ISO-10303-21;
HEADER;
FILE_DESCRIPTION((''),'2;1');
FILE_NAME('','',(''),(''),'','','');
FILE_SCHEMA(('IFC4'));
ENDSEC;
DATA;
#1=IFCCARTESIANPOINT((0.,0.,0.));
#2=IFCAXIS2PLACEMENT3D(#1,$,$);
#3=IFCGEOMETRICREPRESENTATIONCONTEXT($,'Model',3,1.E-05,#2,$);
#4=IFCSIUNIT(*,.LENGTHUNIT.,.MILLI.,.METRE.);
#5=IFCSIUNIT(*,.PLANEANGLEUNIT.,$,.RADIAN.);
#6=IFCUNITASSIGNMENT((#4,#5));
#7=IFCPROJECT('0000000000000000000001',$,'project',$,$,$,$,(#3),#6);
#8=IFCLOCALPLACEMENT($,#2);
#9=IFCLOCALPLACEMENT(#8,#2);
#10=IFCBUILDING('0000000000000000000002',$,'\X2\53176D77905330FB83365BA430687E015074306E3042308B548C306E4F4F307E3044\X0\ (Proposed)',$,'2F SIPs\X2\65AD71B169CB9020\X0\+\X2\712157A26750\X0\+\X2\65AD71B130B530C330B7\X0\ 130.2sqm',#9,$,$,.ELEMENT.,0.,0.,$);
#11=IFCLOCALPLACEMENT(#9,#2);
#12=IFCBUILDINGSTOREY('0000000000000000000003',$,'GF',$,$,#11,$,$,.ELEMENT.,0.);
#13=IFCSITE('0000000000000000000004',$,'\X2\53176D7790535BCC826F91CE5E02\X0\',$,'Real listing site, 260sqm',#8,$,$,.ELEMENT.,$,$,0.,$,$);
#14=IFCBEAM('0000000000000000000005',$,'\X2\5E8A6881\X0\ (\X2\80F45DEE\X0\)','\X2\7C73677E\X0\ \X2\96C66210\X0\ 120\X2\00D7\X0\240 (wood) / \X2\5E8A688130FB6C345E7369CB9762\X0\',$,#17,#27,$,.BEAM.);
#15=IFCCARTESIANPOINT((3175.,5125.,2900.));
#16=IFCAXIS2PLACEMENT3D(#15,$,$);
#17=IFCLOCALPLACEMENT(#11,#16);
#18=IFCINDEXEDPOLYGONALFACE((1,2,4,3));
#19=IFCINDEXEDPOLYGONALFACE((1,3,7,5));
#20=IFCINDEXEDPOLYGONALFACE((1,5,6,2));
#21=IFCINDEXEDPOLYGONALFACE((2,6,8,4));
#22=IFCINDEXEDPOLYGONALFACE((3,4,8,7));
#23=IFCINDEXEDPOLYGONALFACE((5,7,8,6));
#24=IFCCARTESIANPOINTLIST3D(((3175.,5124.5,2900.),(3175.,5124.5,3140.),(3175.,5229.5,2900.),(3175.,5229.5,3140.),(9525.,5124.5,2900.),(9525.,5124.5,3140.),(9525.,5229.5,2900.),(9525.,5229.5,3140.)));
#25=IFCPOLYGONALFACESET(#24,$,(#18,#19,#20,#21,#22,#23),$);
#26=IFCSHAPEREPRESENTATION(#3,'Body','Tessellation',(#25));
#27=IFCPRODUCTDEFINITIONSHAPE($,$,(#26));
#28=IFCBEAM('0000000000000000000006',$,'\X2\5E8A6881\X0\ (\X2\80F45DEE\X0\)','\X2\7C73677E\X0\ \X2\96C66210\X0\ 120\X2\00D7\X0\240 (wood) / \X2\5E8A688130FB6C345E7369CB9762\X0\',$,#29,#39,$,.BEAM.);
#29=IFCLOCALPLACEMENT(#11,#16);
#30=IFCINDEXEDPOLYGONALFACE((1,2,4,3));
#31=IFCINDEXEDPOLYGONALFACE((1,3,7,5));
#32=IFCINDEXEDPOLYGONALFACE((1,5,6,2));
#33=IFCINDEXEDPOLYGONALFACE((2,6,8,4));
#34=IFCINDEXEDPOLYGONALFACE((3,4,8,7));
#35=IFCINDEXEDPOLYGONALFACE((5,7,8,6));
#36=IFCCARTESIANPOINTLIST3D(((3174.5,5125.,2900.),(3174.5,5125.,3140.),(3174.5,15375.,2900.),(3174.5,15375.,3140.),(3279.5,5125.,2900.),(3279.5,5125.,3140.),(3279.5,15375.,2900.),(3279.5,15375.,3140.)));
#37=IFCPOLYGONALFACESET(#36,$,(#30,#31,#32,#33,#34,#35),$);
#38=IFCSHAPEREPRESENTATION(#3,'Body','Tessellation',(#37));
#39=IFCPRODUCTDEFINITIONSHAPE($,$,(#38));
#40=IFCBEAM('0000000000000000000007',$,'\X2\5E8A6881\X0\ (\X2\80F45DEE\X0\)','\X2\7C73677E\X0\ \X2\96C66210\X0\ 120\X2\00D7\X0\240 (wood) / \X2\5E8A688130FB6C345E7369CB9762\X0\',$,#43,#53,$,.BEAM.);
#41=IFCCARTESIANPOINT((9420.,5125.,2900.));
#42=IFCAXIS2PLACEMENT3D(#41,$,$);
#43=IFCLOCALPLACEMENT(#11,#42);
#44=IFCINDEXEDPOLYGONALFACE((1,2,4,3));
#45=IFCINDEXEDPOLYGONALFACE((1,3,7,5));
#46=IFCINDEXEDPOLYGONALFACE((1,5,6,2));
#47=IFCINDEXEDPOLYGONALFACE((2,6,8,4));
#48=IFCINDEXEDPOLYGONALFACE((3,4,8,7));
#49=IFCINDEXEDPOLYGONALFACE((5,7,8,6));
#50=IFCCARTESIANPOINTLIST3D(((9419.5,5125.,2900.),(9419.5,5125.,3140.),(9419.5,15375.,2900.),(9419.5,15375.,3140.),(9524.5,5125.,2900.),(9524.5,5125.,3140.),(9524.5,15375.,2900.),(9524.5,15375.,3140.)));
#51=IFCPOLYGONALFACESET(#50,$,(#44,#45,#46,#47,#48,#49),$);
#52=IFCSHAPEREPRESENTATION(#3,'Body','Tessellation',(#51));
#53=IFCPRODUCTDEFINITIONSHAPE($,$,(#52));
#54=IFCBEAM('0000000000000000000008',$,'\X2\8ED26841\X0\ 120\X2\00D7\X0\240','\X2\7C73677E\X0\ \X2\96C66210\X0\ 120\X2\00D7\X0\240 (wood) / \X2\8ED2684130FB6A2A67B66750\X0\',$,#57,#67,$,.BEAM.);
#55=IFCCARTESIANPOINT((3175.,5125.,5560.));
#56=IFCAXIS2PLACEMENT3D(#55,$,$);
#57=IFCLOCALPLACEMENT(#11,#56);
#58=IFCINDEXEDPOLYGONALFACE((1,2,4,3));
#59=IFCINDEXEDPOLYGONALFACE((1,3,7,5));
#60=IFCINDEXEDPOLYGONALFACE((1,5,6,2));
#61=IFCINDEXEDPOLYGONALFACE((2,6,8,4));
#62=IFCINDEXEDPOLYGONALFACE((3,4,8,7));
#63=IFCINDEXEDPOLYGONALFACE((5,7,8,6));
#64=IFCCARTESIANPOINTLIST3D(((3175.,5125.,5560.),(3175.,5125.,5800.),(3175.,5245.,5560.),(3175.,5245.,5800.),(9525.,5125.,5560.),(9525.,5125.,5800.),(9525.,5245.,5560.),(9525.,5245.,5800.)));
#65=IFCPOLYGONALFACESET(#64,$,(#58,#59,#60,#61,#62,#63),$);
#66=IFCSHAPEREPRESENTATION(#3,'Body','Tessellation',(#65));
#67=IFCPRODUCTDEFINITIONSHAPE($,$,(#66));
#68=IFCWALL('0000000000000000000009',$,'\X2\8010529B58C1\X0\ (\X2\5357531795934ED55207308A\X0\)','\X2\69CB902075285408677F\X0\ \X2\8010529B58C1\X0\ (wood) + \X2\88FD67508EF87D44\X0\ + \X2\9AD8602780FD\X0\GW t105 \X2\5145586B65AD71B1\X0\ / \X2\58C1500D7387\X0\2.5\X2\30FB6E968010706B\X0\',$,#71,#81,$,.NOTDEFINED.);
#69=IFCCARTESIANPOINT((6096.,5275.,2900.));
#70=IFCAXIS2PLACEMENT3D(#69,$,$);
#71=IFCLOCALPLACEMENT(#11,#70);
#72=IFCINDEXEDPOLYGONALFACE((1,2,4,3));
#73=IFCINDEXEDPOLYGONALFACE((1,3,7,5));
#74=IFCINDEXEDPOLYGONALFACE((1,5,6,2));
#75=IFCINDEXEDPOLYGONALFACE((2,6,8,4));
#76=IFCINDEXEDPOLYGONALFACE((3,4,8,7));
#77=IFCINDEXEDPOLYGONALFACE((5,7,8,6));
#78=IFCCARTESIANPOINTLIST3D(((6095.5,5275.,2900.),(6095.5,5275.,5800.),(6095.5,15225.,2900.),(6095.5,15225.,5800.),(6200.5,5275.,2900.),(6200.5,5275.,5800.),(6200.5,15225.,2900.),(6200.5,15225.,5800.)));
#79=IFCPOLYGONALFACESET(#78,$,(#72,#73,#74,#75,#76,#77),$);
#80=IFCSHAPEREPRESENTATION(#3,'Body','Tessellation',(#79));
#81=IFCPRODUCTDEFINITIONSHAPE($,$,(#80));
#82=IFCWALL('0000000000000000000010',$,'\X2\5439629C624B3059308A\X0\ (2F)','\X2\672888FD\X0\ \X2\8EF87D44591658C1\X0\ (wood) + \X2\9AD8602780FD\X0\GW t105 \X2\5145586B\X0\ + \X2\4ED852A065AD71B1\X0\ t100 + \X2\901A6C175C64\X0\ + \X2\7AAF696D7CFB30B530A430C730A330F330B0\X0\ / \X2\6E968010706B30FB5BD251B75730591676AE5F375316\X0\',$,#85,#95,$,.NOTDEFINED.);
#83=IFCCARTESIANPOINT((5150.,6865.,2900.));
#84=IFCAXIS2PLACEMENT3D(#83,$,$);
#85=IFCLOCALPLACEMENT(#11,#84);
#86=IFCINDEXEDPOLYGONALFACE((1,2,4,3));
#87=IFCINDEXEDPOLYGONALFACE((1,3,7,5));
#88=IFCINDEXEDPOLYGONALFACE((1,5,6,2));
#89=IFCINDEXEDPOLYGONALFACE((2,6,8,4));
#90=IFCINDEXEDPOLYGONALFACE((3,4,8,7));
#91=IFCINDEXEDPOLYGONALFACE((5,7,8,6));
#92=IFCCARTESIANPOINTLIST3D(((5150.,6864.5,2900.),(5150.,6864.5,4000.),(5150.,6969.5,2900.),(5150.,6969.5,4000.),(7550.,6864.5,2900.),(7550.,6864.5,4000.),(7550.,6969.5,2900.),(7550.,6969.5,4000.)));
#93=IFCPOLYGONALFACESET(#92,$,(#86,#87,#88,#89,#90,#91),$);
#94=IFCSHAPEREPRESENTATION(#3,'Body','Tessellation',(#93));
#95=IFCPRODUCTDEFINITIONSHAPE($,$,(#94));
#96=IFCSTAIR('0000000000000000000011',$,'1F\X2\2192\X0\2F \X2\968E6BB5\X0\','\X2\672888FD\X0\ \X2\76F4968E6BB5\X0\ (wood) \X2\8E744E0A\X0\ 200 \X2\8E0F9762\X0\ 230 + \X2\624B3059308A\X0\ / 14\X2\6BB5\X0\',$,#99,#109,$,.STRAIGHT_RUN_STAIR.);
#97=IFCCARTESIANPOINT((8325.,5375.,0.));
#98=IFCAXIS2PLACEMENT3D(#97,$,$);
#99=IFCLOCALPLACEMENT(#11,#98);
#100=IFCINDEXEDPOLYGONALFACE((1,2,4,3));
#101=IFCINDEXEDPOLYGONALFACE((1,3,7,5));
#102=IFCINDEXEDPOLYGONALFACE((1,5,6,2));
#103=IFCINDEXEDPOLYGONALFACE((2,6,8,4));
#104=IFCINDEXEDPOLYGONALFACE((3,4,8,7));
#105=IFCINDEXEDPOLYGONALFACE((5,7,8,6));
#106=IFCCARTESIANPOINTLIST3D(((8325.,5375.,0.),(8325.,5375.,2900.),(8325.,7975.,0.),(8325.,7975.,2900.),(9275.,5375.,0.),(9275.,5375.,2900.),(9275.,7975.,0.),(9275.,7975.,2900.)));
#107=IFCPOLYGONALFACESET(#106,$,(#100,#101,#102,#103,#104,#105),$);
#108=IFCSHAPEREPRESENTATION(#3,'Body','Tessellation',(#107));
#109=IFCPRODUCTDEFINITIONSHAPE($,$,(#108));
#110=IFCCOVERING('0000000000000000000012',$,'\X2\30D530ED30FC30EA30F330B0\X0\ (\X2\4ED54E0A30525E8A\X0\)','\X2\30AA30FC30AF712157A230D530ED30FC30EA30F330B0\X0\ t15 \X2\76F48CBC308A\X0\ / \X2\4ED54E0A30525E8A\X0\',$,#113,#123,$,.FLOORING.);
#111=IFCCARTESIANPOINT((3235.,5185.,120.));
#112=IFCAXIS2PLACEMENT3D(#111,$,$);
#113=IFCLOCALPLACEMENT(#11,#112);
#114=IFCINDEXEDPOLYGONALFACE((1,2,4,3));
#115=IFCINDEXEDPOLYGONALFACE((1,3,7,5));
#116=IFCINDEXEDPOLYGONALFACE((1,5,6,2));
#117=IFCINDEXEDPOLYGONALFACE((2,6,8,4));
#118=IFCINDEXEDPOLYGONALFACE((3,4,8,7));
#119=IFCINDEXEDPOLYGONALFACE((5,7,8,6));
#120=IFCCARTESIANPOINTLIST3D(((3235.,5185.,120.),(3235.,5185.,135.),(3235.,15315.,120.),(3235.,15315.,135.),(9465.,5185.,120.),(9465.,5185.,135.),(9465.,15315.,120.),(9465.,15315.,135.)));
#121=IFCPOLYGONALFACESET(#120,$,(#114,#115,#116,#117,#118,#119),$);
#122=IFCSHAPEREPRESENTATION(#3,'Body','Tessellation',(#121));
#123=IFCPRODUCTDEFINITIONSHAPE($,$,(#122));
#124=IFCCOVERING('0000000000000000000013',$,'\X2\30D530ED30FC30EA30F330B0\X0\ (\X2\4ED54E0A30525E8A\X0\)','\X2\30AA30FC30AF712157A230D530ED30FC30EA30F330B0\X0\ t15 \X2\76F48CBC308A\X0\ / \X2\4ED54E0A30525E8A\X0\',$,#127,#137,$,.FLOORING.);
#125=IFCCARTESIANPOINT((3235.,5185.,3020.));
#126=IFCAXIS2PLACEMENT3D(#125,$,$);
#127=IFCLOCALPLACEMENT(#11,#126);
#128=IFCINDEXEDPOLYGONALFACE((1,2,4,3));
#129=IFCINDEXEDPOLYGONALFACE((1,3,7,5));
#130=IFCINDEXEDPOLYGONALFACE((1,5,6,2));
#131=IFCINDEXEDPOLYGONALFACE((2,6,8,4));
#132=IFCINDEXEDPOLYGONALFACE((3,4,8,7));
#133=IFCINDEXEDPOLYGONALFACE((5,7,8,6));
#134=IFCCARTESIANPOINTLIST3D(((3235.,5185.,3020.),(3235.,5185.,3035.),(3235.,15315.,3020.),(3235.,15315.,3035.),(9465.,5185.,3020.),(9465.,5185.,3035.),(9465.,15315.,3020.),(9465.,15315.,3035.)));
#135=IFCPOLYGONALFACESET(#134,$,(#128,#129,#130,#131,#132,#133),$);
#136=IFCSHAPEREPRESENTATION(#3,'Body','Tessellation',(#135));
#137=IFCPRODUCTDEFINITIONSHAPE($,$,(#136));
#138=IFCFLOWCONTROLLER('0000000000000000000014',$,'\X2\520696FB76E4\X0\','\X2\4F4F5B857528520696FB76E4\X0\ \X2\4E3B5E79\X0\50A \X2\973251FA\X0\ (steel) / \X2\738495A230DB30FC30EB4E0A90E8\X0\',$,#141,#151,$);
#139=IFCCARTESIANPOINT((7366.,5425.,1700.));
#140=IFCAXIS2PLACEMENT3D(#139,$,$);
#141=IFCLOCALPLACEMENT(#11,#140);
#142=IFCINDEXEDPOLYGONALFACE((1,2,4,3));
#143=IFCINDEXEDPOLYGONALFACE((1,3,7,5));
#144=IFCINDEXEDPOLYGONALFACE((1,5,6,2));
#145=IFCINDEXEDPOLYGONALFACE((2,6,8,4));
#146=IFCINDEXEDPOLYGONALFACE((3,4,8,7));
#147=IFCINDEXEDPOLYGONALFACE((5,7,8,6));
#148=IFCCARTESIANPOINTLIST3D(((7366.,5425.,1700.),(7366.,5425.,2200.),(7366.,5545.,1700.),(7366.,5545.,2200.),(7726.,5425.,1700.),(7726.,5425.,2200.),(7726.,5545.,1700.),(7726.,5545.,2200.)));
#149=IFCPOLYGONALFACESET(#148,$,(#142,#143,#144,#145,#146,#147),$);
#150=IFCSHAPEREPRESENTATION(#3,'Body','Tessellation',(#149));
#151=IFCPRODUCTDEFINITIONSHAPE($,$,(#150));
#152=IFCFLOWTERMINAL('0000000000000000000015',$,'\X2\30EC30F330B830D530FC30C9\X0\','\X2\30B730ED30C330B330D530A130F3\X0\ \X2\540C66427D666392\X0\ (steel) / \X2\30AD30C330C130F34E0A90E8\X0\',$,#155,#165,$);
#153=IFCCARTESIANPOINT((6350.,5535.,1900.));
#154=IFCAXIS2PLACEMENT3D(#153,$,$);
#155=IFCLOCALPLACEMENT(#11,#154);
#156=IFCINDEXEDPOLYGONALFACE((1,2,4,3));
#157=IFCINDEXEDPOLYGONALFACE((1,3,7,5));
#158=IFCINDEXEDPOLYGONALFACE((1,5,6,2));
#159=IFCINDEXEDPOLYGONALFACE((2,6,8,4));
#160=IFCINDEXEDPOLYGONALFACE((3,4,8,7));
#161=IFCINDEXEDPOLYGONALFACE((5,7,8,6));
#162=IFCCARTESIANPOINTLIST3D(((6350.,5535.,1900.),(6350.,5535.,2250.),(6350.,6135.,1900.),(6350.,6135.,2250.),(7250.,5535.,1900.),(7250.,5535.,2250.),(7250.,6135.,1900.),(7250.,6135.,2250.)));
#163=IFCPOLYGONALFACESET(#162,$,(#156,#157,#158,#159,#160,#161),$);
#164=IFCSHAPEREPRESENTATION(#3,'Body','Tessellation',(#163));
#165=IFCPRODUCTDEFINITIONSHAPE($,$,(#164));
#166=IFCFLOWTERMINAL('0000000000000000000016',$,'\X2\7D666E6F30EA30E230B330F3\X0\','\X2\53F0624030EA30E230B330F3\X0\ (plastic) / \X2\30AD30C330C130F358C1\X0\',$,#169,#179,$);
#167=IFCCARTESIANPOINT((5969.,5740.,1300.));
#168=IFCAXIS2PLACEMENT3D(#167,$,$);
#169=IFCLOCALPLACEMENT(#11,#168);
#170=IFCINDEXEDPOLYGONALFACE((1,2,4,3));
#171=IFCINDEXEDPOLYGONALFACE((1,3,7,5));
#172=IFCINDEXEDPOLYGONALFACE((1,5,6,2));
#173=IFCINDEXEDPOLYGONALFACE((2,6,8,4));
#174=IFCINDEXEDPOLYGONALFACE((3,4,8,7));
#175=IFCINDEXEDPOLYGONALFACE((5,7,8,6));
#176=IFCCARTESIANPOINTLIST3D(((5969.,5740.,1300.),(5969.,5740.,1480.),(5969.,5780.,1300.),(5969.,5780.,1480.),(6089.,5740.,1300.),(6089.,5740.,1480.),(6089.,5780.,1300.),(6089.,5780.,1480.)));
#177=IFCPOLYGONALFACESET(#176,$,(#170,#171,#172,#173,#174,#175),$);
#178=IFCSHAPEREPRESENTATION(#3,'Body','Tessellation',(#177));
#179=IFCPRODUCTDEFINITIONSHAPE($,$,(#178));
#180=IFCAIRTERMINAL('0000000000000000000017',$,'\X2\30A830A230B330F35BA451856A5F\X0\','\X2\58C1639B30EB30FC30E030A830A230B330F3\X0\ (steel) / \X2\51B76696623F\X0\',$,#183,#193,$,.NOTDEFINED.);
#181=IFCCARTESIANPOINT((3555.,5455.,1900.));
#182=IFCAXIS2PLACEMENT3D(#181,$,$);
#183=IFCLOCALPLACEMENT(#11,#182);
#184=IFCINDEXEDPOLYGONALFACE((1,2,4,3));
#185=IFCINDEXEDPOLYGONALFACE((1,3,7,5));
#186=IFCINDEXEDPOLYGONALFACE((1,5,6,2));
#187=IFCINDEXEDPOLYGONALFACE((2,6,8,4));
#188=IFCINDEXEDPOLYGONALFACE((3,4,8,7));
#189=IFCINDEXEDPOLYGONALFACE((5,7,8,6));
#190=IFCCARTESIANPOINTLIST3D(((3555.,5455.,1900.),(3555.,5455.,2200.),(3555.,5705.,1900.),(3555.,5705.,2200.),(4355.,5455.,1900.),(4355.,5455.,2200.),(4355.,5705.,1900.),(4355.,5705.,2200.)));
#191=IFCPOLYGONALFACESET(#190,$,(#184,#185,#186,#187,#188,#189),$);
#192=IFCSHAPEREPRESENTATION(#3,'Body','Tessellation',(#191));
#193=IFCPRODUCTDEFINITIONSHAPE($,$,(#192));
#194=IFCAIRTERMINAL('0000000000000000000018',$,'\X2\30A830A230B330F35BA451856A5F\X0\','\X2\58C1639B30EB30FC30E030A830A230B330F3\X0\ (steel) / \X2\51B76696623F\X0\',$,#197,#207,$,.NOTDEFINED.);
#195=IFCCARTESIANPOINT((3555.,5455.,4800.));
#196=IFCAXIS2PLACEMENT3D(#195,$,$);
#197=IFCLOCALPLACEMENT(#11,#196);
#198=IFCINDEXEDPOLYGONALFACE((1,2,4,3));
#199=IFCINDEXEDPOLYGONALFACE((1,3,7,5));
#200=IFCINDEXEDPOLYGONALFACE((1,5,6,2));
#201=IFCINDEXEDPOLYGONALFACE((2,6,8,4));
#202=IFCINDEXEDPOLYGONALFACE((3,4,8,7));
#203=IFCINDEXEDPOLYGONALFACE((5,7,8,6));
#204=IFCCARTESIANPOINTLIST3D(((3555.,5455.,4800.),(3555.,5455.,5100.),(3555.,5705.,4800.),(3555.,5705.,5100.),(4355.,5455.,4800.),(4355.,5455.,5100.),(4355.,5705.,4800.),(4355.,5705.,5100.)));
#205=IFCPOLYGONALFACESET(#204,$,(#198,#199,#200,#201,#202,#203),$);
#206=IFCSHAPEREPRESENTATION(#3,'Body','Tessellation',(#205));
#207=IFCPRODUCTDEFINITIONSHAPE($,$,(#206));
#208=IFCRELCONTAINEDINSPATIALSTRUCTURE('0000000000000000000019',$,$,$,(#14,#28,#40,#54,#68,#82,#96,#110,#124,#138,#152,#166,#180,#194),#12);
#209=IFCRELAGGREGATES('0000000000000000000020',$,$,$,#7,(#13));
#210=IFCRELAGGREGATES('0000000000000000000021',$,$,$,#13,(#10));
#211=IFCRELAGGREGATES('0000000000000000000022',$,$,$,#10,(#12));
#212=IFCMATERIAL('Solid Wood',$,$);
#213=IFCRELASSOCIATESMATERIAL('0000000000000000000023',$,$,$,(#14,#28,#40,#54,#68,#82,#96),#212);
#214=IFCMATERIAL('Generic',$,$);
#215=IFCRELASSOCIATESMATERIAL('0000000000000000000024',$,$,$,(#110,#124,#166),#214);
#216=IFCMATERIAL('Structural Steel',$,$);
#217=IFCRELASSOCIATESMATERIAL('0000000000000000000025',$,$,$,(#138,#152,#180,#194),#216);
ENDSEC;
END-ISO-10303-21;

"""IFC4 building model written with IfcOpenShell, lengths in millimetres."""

from ifc_helpers import new_model, si_unit, frame, frame_2d, origin, place, context, project, spatial, rectangle, extrude, material, element, save


model = new_model("IFC4")

# Units and contexts
model_context = context("Model", 3, precision=1e-05, world=origin())
ifc_project = project(units=[si_unit("LENGTHUNIT", "METRE", prefix="MILLI"), si_unit("PLANEANGLEUNIT", "RADIAN")], contexts=[model_context])

# Site, building, storey
site_placement = place(None, origin())
site = spatial("IfcSite", under=ifc_project, at=site_placement, Name="北海道富良野市", ObjectType="Real listing site, 260sqm", CompositionType="ELEMENT", RefElevation=0.0)
building_placement = place(site_placement, origin())
building = spatial("IfcBuilding", under=site, at=building_placement, Name="北海道・茶室と縁側のある和の住まい (Proposed)", ObjectType="2F SIPs断熱構造+無垢材+断熱サッシ 130.2sqm", CompositionType="ELEMENT", ElevationOfRefHeight=0.0, ElevationOfTerrain=0.0)
storey_placement = place(building_placement, origin())
storey = spatial("IfcBuildingStorey", under=building, at=storey_placement, Name="GF", CompositionType="ELEMENT", Elevation=0.0)

# Shared definitions
ifc_material_1 = material(Name="Solid Wood")

# Beams
beam_1_placement = place(storey_placement, frame((3175.0, 5125.0, 2900.0)))
element("IfcBeam", 1, at=beam_1_placement, inside=storey, material=ifc_material_1, Name="床梁 (胴差)", Description="米松 集成 120×240 (wood) / 床梁・水平構面", PredefinedType="BEAM", context=model_context, shape_type="SweptSolid", body=[
    extrude(rectangle(XDim=6350.0, YDim=105.0, at=frame_2d((3175.0, 52.0))), frame((3175.0, 5125.0, 2900.0)), (0.0, 0.0, 1.0), 240.0),
])
beam_2_placement = place(storey_placement, frame((3175.0, 5125.0, 2900.0)))
element("IfcBeam", 2, at=beam_2_placement, inside=storey, material=ifc_material_1, Name="床梁 (胴差)", Description="米松 集成 120×240 (wood) / 床梁・水平構面", PredefinedType="BEAM", context=model_context, shape_type="SweptSolid", body=[
    extrude(rectangle(XDim=105.0, YDim=10250.0, at=frame_2d((52.0, 5125.0))), frame((3175.0, 5125.0, 2900.0)), (0.0, 0.0, 1.0), 240.0),
])
beam_3_placement = place(storey_placement, frame((9420.0, 5125.0, 2900.0)))
element("IfcBeam", 3, at=beam_3_placement, inside=storey, material=ifc_material_1, Name="床梁 (胴差)", Description="米松 集成 120×240 (wood) / 床梁・水平構面", PredefinedType="BEAM", context=model_context, shape_type="SweptSolid", body=[
    extrude(rectangle(XDim=105.0, YDim=10250.0, at=frame_2d((52.0, 5125.0))), frame((9420.0, 5125.0, 2900.0)), (0.0, 0.0, 1.0), 240.0),
])
beam_4_placement = place(storey_placement, frame((3175.0, 5125.0, 5560.0)))
element("IfcBeam", 4, at=beam_4_placement, inside=storey, material=ifc_material_1, Name="軒桁 120×240", Description="米松 集成 120×240 (wood) / 軒桁・横架材", PredefinedType="BEAM", context=model_context, shape_type="SweptSolid", body=[
    extrude(rectangle(XDim=6350.0, YDim=120.0, at=frame_2d((3175.0, 60.0))), frame((3175.0, 5125.0, 5560.0)), (0.0, 0.0, 1.0), 240.0),
])

# Walls
wall_1_placement = place(storey_placement, frame((6096.0, 5275.0, 2900.0)))
element("IfcWall", 5, at=wall_1_placement, inside=storey, material=ifc_material_1, Name="耐力壁 (南北間仕切り)", Description="構造用合板 耐力壁 (wood) + 製材軸組 + 高性能GW t105 充填断熱 / 壁倍率2.5・準耐火", PredefinedType="NOTDEFINED", context=model_context, shape_type="SweptSolid", body=[
    extrude(rectangle(XDim=105.0, YDim=9950.0, at=frame_2d((52.0, 4975.0))), frame((6096.0, 5275.0, 2900.0)), (0.0, 0.0, 1.0), 2900.0),
])
wall_2_placement = place(storey_placement, frame((5150.0, 6865.0, 2900.0)))
element("IfcWall", 6, at=wall_2_placement, inside=storey, material=ifc_material_1, Name="吹抜手すり (2F)", Description="木製 軸組外壁 (wood) + 高性能GW t105 充填 + 付加断熱 t100 + 通気層 + 窯業系サイディング / 準耐火・寒冷地外皮強化", PredefinedType="NOTDEFINED", context=model_context, shape_type="SweptSolid", body=[
    extrude(rectangle(XDim=2400.0, YDim=105.0, at=frame_2d((1200.0, 52.0))), frame((5150.0, 6865.0, 2900.0)), (0.0, 0.0, 1.0), 1100.0),
])

# Stair
stair_placement = place(storey_placement, frame((8325.0, 5375.0, 0.0)))
element("IfcStair", 7, at=stair_placement, inside=storey, material=ifc_material_1, Name="1F→2F 階段", Description="木製 直階段 (wood) 蹴上 200 踏面 230 + 手すり / 14段", PredefinedType="STRAIGHT_RUN_STAIR", context=model_context, shape_type="SweptSolid", body=[
    extrude(rectangle(XDim=950.0, YDim=2600.0, at=frame_2d((475.0, 1300.0))), frame((8325.0, 5375.0, 0.0)), (0.0, 0.0, 1.0), 2900.0),
])

# Coverings
ifc_material_2 = material(Name="Generic")
covering_1_placement = place(storey_placement, frame((3235.0, 5185.0, 120.0)))
element("IfcCovering", 8, at=covering_1_placement, inside=storey, material=ifc_material_2, Name="フローリング (仕上げ床)", Description="オーク無垢フローリング t15 直貼り / 仕上げ床", PredefinedType="FLOORING", context=model_context, shape_type="SweptSolid", body=[
    extrude(rectangle(XDim=6230.0, YDim=10130.0, at=frame_2d((3115.0, 5065.0))), frame((3235.0, 5185.0, 120.0)), (0.0, 0.0, 1.0), 15.0),
])
covering_2_placement = place(storey_placement, frame((3235.0, 5185.0, 3020.0)))
element("IfcCovering", 9, at=covering_2_placement, inside=storey, material=ifc_material_2, Name="フローリング (仕上げ床)", Description="オーク無垢フローリング t15 直貼り / 仕上げ床", PredefinedType="FLOORING", context=model_context, shape_type="SweptSolid", body=[
    extrude(rectangle(XDim=6230.0, YDim=10130.0, at=frame_2d((3115.0, 5065.0))), frame((3235.0, 5185.0, 3020.0)), (0.0, 0.0, 1.0), 15.0),
])

# Flow controller
ifc_material_3 = material(Name="Structural Steel")
flow_controller_placement = place(storey_placement, frame((7366.0, 5425.0, 1700.0)))
element("IfcFlowController", 10, at=flow_controller_placement, inside=storey, material=ifc_material_3, Name="分電盤", Description="住宅用分電盤 主幹50A 露出 (steel) / 玄関ホール上部", context=model_context, shape_type="SweptSolid", body=[
    extrude(rectangle(XDim=360.0, YDim=120.0, at=frame_2d((180.0, 60.0))), frame((7366.0, 5425.0, 1700.0)), (0.0, 0.0, 1.0), 500.0),
])

# Flow terminals
flow_terminal_1_placement = place(storey_placement, frame((6350.0, 5535.0, 1900.0)))
element("IfcFlowTerminal", 11, at=flow_terminal_1_placement, inside=storey, material=ifc_material_3, Name="レンジフード", Description="シロッコファン 同時給排 (steel) / キッチン上部", context=model_context, shape_type="SweptSolid", body=[
    extrude(rectangle(XDim=900.0, YDim=600.0, at=frame_2d((450.0, 300.0))), frame((6350.0, 5535.0, 1900.0)), (0.0, 0.0, 1.0), 350.0),
])
flow_terminal_2_placement = place(storey_placement, frame((5969.0, 5740.0, 1300.0)))
element("IfcFlowTerminal", 12, at=flow_terminal_2_placement, inside=storey, material=ifc_material_2, Name="給湯リモコン", Description="台所リモコン (plastic) / キッチン壁", context=model_context, shape_type="SweptSolid", body=[
    extrude(rectangle(XDim=120.0, YDim=40.0, at=frame_2d((60.0, 20.0))), frame((5969.0, 5740.0, 1300.0)), (0.0, 0.0, 1.0), 180.0),
])

# Air terminals
air_terminal_1_placement = place(storey_placement, frame((3555.0, 5455.0, 1900.0)))
element("IfcAirTerminal", 13, at=air_terminal_1_placement, inside=storey, material=ifc_material_3, Name="エアコン室内機", Description="壁掛ルームエアコン (steel) / 冷暖房", PredefinedType="NOTDEFINED", context=model_context, shape_type="SweptSolid", body=[
    extrude(rectangle(XDim=800.0, YDim=250.0, at=frame_2d((400.0, 125.0))), frame((3555.0, 5455.0, 1900.0)), (0.0, 0.0, 1.0), 300.0),
])
air_terminal_2_placement = place(storey_placement, frame((3555.0, 5455.0, 4800.0)))
element("IfcAirTerminal", 14, at=air_terminal_2_placement, inside=storey, material=ifc_material_3, Name="エアコン室内機", Description="壁掛ルームエアコン (steel) / 冷暖房", PredefinedType="NOTDEFINED", context=model_context, shape_type="SweptSolid", body=[
    extrude(rectangle(XDim=800.0, YDim=250.0, at=frame_2d((400.0, 125.0))), frame((3555.0, 5455.0, 4800.0)), (0.0, 0.0, 1.0), 300.0),
])

save(model, "model.ifc")
